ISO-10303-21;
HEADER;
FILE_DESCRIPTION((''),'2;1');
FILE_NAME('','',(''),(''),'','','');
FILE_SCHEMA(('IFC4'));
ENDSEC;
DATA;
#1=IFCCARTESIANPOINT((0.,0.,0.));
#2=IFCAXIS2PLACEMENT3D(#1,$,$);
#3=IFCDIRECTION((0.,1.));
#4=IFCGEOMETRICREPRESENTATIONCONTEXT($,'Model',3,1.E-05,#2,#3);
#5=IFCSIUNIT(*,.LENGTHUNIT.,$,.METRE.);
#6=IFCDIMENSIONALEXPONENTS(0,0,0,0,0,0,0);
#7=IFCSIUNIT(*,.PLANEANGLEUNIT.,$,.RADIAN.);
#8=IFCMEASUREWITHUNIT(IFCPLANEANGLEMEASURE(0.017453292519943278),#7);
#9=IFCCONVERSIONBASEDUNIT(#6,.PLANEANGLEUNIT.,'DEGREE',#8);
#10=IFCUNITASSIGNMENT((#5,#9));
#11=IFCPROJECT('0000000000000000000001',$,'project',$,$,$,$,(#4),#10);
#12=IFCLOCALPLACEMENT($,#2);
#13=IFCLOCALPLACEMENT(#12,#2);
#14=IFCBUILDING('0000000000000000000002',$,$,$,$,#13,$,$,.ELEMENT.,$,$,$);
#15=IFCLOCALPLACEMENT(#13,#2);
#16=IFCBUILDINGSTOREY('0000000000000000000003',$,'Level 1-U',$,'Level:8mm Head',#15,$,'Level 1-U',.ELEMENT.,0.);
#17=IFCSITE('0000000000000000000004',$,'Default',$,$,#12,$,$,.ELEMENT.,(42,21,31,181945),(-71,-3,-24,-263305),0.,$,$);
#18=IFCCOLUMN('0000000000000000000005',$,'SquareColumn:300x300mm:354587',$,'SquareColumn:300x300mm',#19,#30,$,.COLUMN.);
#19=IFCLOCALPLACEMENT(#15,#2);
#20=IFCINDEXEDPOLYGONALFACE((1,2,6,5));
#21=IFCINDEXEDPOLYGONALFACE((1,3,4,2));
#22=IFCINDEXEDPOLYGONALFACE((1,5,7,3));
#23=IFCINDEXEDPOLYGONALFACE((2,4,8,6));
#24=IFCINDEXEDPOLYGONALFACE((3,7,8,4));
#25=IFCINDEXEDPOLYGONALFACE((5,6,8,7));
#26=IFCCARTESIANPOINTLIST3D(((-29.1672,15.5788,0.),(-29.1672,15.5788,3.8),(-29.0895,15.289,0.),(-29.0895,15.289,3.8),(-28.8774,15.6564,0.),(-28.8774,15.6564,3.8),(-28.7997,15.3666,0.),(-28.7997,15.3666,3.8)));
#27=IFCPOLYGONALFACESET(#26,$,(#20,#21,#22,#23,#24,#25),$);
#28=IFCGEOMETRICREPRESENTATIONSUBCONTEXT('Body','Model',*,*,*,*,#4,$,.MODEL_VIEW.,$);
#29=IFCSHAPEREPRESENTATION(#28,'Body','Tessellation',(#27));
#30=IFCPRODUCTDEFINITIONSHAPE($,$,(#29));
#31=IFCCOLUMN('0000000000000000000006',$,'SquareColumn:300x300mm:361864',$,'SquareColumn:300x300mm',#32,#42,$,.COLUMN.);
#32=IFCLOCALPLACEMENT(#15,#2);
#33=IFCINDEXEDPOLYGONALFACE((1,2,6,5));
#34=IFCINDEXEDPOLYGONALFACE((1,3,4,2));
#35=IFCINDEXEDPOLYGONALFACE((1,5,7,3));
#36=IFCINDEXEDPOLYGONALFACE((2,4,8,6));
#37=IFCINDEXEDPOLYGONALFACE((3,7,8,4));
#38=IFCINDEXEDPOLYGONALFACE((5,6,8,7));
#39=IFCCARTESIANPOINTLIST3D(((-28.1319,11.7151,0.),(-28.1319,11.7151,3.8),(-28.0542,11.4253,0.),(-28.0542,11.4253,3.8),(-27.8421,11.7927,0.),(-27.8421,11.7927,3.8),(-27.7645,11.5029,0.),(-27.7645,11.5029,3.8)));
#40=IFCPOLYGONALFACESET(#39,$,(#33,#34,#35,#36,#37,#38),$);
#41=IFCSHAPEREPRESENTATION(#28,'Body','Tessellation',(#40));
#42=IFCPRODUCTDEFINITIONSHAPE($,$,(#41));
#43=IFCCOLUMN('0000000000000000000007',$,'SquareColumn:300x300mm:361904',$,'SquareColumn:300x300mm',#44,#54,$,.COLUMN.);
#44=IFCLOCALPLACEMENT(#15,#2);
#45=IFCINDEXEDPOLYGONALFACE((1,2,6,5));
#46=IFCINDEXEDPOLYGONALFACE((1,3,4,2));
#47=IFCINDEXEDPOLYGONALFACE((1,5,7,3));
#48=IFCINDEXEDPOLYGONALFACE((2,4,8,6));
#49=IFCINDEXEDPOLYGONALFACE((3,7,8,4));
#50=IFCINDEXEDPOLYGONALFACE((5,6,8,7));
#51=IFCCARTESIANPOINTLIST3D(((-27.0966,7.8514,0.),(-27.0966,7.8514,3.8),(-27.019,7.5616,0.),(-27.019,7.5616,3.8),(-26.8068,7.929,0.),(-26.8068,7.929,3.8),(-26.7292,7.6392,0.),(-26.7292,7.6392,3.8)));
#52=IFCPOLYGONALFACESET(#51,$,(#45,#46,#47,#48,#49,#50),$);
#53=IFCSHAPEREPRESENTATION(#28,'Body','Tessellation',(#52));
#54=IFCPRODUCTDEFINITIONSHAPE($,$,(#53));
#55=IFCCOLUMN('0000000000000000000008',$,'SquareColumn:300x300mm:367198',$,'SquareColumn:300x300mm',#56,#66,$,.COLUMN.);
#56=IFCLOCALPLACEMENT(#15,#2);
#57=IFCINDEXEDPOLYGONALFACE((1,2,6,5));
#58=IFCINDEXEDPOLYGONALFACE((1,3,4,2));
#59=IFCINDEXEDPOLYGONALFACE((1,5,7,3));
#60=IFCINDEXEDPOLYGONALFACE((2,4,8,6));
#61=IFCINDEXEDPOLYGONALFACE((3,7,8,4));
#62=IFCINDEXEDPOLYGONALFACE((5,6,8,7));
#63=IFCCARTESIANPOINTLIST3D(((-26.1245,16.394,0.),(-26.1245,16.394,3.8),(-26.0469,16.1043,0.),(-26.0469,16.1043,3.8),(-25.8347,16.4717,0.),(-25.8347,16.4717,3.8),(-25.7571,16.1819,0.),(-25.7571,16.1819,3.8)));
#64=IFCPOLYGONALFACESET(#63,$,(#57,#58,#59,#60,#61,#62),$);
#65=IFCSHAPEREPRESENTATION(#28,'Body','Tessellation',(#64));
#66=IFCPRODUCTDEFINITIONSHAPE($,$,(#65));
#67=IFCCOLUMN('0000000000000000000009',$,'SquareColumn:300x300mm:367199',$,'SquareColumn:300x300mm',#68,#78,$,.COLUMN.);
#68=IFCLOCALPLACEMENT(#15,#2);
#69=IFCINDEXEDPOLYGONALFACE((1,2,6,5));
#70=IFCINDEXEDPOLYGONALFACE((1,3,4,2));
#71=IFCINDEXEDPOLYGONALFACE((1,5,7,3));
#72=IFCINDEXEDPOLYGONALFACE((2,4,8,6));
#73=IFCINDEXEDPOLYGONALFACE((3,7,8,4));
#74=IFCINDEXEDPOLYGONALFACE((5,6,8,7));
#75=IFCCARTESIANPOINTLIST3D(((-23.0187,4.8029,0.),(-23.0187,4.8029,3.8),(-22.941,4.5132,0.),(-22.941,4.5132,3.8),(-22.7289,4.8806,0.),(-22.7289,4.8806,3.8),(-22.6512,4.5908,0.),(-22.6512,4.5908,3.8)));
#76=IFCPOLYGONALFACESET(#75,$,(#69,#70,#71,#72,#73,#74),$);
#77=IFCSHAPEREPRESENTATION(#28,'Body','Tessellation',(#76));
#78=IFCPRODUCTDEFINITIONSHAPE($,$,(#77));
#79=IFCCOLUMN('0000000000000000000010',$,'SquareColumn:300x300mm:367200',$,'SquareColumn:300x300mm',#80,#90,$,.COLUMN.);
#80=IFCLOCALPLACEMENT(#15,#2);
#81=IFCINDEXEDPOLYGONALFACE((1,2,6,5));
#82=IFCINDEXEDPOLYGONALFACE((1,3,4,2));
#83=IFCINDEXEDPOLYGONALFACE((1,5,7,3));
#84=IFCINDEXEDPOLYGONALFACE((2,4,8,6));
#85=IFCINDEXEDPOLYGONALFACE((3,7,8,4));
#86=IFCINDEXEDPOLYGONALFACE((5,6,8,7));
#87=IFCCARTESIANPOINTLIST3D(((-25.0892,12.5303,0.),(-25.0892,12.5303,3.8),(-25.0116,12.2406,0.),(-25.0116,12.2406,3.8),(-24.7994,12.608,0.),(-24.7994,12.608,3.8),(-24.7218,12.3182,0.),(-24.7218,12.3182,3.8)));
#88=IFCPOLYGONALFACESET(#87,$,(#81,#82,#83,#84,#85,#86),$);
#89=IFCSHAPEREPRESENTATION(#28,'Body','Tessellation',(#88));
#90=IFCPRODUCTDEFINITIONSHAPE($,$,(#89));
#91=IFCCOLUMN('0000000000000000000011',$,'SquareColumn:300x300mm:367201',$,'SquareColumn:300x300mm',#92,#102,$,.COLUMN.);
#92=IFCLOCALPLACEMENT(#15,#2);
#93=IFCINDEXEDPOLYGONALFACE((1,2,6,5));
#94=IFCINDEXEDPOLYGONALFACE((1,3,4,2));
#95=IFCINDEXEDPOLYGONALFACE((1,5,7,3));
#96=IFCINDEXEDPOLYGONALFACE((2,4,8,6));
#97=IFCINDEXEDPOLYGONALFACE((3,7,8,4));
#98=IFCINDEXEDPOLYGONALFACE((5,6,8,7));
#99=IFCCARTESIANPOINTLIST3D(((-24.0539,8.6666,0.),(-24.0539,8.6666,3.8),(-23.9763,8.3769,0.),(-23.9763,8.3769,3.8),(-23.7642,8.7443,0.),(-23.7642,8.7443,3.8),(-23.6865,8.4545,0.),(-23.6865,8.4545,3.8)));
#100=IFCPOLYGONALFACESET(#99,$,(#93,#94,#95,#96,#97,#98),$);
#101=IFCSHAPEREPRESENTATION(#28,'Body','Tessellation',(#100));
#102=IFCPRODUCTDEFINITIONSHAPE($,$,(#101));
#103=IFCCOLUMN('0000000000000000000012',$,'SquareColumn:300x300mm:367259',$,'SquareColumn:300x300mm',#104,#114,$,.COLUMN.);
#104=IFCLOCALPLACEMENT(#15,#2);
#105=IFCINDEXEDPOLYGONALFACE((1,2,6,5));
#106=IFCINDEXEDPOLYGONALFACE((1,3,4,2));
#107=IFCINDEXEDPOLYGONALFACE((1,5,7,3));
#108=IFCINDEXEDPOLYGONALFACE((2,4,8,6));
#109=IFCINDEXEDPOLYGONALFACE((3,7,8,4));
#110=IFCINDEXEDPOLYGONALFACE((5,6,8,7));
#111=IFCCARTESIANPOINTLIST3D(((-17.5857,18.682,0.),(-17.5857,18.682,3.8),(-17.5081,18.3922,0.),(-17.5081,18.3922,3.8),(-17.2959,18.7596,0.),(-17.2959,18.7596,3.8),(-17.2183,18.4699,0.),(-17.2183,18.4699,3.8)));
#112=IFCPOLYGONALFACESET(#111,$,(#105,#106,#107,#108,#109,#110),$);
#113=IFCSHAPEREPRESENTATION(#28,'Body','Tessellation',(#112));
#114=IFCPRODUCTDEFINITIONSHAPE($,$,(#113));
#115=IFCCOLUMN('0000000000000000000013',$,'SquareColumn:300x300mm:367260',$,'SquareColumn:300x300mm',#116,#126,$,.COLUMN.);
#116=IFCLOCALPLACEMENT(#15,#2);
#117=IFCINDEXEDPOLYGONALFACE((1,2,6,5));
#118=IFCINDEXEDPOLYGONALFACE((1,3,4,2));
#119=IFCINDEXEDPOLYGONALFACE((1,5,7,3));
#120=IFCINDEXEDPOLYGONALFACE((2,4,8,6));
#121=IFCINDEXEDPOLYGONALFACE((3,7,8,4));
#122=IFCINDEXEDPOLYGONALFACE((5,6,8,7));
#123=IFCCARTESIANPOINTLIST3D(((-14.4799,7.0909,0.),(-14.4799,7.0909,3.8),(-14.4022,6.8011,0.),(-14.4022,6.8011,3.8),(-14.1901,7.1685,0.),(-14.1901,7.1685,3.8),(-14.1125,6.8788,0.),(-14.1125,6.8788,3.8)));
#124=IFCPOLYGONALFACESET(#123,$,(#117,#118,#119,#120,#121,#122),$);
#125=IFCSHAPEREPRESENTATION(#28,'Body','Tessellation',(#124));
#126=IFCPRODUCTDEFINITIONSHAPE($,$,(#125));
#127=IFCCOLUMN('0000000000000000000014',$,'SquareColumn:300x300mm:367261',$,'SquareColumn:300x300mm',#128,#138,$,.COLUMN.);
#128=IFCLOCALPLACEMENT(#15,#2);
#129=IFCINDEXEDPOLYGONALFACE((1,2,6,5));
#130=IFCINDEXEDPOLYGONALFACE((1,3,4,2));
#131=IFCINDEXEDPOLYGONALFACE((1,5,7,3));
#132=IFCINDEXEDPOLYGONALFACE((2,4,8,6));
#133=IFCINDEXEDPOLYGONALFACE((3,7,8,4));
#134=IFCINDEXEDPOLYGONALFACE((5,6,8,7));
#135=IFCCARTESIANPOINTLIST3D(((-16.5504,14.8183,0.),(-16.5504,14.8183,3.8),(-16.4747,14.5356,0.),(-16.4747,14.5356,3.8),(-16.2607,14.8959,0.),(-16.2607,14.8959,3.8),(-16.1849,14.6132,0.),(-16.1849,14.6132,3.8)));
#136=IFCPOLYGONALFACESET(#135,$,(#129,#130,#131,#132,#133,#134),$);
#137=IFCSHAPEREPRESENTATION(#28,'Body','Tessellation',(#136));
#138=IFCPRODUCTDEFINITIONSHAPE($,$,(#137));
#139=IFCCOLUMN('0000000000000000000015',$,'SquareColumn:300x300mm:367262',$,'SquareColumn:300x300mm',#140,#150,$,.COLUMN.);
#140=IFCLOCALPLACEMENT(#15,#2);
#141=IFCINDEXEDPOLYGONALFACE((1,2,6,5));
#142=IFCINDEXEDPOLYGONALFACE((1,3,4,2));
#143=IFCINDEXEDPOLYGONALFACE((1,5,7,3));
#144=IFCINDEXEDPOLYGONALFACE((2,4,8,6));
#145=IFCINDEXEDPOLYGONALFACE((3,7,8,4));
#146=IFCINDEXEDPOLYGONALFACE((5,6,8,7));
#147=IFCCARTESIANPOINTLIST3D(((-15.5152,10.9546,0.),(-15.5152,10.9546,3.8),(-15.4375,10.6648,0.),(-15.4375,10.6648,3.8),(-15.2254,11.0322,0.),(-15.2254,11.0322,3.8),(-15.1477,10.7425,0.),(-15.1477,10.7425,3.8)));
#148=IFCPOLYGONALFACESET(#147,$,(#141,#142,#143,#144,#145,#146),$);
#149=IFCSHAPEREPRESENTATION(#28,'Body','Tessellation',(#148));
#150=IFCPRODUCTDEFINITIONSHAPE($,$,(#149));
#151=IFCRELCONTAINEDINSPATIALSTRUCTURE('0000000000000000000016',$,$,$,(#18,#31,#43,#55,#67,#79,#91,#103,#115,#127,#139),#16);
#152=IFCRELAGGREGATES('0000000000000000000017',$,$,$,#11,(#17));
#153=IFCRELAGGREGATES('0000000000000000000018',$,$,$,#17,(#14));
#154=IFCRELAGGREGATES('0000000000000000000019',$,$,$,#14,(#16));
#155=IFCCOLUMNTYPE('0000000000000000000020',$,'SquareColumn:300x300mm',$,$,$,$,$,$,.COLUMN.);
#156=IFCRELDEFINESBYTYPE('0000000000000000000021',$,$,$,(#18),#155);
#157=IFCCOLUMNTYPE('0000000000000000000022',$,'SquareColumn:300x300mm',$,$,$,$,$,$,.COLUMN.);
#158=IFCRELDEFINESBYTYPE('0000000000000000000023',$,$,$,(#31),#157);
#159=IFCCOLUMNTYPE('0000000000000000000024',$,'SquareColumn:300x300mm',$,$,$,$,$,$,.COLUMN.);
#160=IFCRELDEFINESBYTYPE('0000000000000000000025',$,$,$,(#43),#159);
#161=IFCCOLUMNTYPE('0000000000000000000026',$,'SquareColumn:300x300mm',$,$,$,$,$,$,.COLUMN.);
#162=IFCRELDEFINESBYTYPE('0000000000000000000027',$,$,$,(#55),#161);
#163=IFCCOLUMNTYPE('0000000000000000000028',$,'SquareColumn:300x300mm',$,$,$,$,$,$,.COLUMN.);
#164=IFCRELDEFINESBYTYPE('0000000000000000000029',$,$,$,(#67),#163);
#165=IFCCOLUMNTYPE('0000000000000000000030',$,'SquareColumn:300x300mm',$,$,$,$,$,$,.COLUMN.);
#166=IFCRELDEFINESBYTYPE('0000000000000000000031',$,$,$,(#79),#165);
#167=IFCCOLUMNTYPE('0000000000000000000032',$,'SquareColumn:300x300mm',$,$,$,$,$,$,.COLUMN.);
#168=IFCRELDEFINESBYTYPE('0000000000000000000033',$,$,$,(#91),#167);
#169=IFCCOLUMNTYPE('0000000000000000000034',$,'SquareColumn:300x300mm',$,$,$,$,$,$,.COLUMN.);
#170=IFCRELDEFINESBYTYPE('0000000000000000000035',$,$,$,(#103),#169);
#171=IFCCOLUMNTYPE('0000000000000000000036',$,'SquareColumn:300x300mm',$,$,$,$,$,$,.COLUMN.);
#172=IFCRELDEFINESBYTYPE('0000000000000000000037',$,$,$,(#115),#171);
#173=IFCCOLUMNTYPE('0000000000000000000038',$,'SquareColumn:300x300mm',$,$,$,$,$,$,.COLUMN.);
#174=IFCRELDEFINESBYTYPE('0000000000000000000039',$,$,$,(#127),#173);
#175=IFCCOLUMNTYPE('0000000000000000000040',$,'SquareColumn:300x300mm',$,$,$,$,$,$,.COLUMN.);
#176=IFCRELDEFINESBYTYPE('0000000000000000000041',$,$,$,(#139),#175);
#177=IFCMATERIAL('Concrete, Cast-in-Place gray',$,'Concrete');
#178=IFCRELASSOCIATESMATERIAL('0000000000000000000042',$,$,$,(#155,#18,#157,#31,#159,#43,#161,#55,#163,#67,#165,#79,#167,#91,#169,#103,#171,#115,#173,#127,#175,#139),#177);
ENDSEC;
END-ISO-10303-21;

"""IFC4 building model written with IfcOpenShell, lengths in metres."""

from ifc_helpers import new_model, entity, si_unit, converted_unit, direction, frame, origin, place, context, subcontext, project, spatial, indexed_curve, outline, extrude, source, transform, mapped, material, type_object, type_shapes, element, save


model = new_model("IFC4")

# Units and contexts
model_context = context("Model", 3, precision=1e-05, world=origin(), true_north=direction((0.0, 1.0)))
body_context = subcontext(model_context, "Body", "Model", "MODEL_VIEW")
ifc_project = project(units=[si_unit("LENGTHUNIT", "METRE"), converted_unit("PLANEANGLEUNIT", "DEGREE", entity("IfcPlaneAngleMeasure", 0.017453292519943278), si_unit("PLANEANGLEUNIT", "RADIAN"), dimensions=[0, 0, 0, 0, 0, 0, 0])], contexts=[model_context])

# Site, building, storey
site_placement = place(None, origin())
site = spatial("IfcSite", under=ifc_project, at=site_placement, Name="Default", CompositionType="ELEMENT", RefLatitude=(42, 21, 31, 181945), RefLongitude=(-71, -3, -24, -263305), RefElevation=0.0)
building_placement = place(site_placement, origin())
building = spatial("IfcBuilding", under=site, at=building_placement, CompositionType="ELEMENT")
storey_placement = place(building_placement, origin())
storey = spatial("IfcBuildingStorey", under=building, at=storey_placement, Name="Level 1-U", ObjectType="Level:8mm Head", LongName="Level 1-U", CompositionType="ELEMENT", Elevation=0.0)

# Columns
ifc_material_1 = material(Name="Concrete, Cast-in-Place gray", Category="Concrete")
column_type_1 = type_object("IfcColumnType", Name="SquareColumn:300x300mm", PredefinedType="COLUMN", material=ifc_material_1)
shared_shape_1 = source(origin(), body_context, "Body", "SweptSolid", [
    extrude(outline(indexed_curve([(-0.15, -0.15), (0.15, -0.15), (0.15, 0.15), (-0.15, 0.15), (-0.15, -0.15)], self_intersect=False)), frame((-28.9835, 15.4727, 0.0), z_axis=(0.0, 0.0, 1.0), x_axis=(-0.258819, 0.965926, 0.0)), (0.0, 0.0, 1.0), 3.8),
])
type_shapes(column_type_1, [shared_shape_1])
column_1_placement = place(storey_placement, origin())
element("IfcColumn", 1, at=column_1_placement, inside=storey, type_object=column_type_1, material=ifc_material_1, Name="SquareColumn:300x300mm:354587", ObjectType="SquareColumn:300x300mm", PredefinedType="COLUMN", context=body_context, shape_type="MappedRepresentation", body=[
    mapped(shared_shape_1, transform((0.0, 0.0, 0.0), scale=1.0)),
])
column_type_2 = type_object("IfcColumnType", Name="SquareColumn:300x300mm", PredefinedType="COLUMN", material=ifc_material_1)
shared_shape_2 = source(origin(), body_context, "Body", "SweptSolid", [
    extrude(outline(indexed_curve([(-0.15, -0.15), (0.15, -0.15), (0.15, 0.15), (-0.15, 0.15), (-0.15, -0.15)], self_intersect=False)), frame((-27.9482, 11.609, 0.0), z_axis=(0.0, 0.0, 1.0), x_axis=(-0.258819, 0.965926, 0.0)), (0.0, 0.0, 1.0), 3.8),
])
type_shapes(column_type_2, [shared_shape_2])
column_2_placement = place(storey_placement, origin())
element("IfcColumn", 2, at=column_2_placement, inside=storey, type_object=column_type_2, material=ifc_material_1, Name="SquareColumn:300x300mm:361864", ObjectType="SquareColumn:300x300mm", PredefinedType="COLUMN", context=body_context, shape_type="MappedRepresentation", body=[
    mapped(shared_shape_2, transform((0.0, 0.0, 0.0), scale=1.0)),
])
column_type_3 = type_object("IfcColumnType", Name="SquareColumn:300x300mm", PredefinedType="COLUMN", material=ifc_material_1)
shared_shape_3 = source(origin(), body_context, "Body", "SweptSolid", [
    extrude(outline(indexed_curve([(-0.15, -0.15), (0.15, -0.15), (0.15, 0.15), (-0.15, 0.15), (-0.15, -0.15)], self_intersect=False)), frame((-26.9129, 7.7453, 0.0), z_axis=(0.0, 0.0, 1.0), x_axis=(-0.258819, 0.965926, 0.0)), (0.0, 0.0, 1.0), 3.8),
])
type_shapes(column_type_3, [shared_shape_3])
column_3_placement = place(storey_placement, origin())
element("IfcColumn", 3, at=column_3_placement, inside=storey, type_object=column_type_3, material=ifc_material_1, Name="SquareColumn:300x300mm:361904", ObjectType="SquareColumn:300x300mm", PredefinedType="COLUMN", context=body_context, shape_type="MappedRepresentation", body=[
    mapped(shared_shape_3, transform((0.0, 0.0, 0.0), scale=1.0)),
])
column_type_4 = type_object("IfcColumnType", Name="SquareColumn:300x300mm", PredefinedType="COLUMN", material=ifc_material_1)
shared_shape_4 = source(origin(), body_context, "Body", "SweptSolid", [
    extrude(outline(indexed_curve([(-0.15, -0.15), (0.15, -0.15), (0.15, 0.15), (-0.15, 0.15), (-0.15, -0.15)], self_intersect=False)), frame((-25.9408, 16.288, 0.0), z_axis=(0.0, 0.0, 1.0), x_axis=(-0.258819, 0.965926, 0.0)), (0.0, 0.0, 1.0), 3.8),
])
type_shapes(column_type_4, [shared_shape_4])
column_4_placement = place(storey_placement, origin())
element("IfcColumn", 4, at=column_4_placement, inside=storey, type_object=column_type_4, material=ifc_material_1, Name="SquareColumn:300x300mm:367198", ObjectType="SquareColumn:300x300mm", PredefinedType="COLUMN", context=body_context, shape_type="MappedRepresentation", body=[
    mapped(shared_shape_4, transform((0.0, 0.0, 0.0), scale=1.0)),
])
column_type_5 = type_object("IfcColumnType", Name="SquareColumn:300x300mm", PredefinedType="COLUMN", material=ifc_material_1)
shared_shape_5 = source(origin(), body_context, "Body", "SweptSolid", [
    extrude(outline(indexed_curve([(-0.15, -0.15), (0.15, -0.15), (0.15, 0.15), (-0.15, 0.15), (-0.15, -0.15)], self_intersect=False)), frame((-22.835, 4.6969, 0.0), z_axis=(0.0, 0.0, 1.0), x_axis=(-0.258819, 0.965926, 0.0)), (0.0, 0.0, 1.0), 3.8),
])
type_shapes(column_type_5, [shared_shape_5])
column_5_placement = place(storey_placement, origin())
element("IfcColumn", 5, at=column_5_placement, inside=storey, type_object=column_type_5, material=ifc_material_1, Name="SquareColumn:300x300mm:367199", ObjectType="SquareColumn:300x300mm", PredefinedType="COLUMN", context=body_context, shape_type="MappedRepresentation", body=[
    mapped(shared_shape_5, transform((0.0, 0.0, 0.0), scale=1.0)),
])
column_type_6 = type_object("IfcColumnType", Name="SquareColumn:300x300mm", PredefinedType="COLUMN", material=ifc_material_1)
shared_shape_6 = source(origin(), body_context, "Body", "SweptSolid", [
    extrude(outline(indexed_curve([(-0.15, -0.15), (0.15, -0.15), (0.15, 0.15), (-0.15, 0.15), (-0.15, -0.15)], self_intersect=False)), frame((-24.9055, 12.4243, 0.0), z_axis=(0.0, 0.0, 1.0), x_axis=(-0.258819, 0.965926, 0.0)), (0.0, 0.0, 1.0), 3.8),
])
type_shapes(column_type_6, [shared_shape_6])
column_6_placement = place(storey_placement, origin())
element("IfcColumn", 6, at=column_6_placement, inside=storey, type_object=column_type_6, material=ifc_material_1, Name="SquareColumn:300x300mm:367200", ObjectType="SquareColumn:300x300mm", PredefinedType="COLUMN", context=body_context, shape_type="MappedRepresentation", body=[
    mapped(shared_shape_6, transform((0.0, 0.0, 0.0), scale=1.0)),
])
column_type_7 = type_object("IfcColumnType", Name="SquareColumn:300x300mm", PredefinedType="COLUMN", material=ifc_material_1)
shared_shape_7 = source(origin(), body_context, "Body", "SweptSolid", [
    extrude(outline(indexed_curve([(-0.15, -0.15), (0.15, -0.15), (0.15, 0.15), (-0.15, 0.15), (-0.15, -0.15)], self_intersect=False)), frame((-23.8702, 8.5606, 0.0), z_axis=(0.0, 0.0, 1.0), x_axis=(-0.258819, 0.965926, 0.0)), (0.0, 0.0, 1.0), 3.8),
])
type_shapes(column_type_7, [shared_shape_7])
column_7_placement = place(storey_placement, origin())
element("IfcColumn", 7, at=column_7_placement, inside=storey, type_object=column_type_7, material=ifc_material_1, Name="SquareColumn:300x300mm:367201", ObjectType="SquareColumn:300x300mm", PredefinedType="COLUMN", context=body_context, shape_type="MappedRepresentation", body=[
    mapped(shared_shape_7, transform((0.0, 0.0, 0.0), scale=1.0)),
])
column_type_8 = type_object("IfcColumnType", Name="SquareColumn:300x300mm", PredefinedType="COLUMN", material=ifc_material_1)
shared_shape_8 = source(origin(), body_context, "Body", "SweptSolid", [
    extrude(outline(indexed_curve([(-0.15, -0.15), (0.15, -0.15), (0.15, 0.15), (-0.15, 0.15), (-0.15, -0.15)], self_intersect=False)), frame((-17.402, 18.5759, 0.0), z_axis=(0.0, 0.0, 1.0), x_axis=(-0.258819, 0.965926, 0.0)), (0.0, 0.0, 1.0), 3.8),
])
type_shapes(column_type_8, [shared_shape_8])
column_8_placement = place(storey_placement, origin())
element("IfcColumn", 8, at=column_8_placement, inside=storey, type_object=column_type_8, material=ifc_material_1, Name="SquareColumn:300x300mm:367259", ObjectType="SquareColumn:300x300mm", PredefinedType="COLUMN", context=body_context, shape_type="MappedRepresentation", body=[
    mapped(shared_shape_8, transform((0.0, 0.0, 0.0), scale=1.0)),
])
column_type_9 = type_object("IfcColumnType", Name="SquareColumn:300x300mm", PredefinedType="COLUMN", material=ifc_material_1)
shared_shape_9 = source(origin(), body_context, "Body", "SweptSolid", [
    extrude(outline(indexed_curve([(-0.15, -0.15), (0.15, -0.15), (0.15, 0.15), (-0.15, 0.15), (-0.15, -0.15)], self_intersect=False)), frame((-14.2962, 6.9848, 0.0), z_axis=(0.0, 0.0, 1.0), x_axis=(-0.258819, 0.965926, 0.0)), (0.0, 0.0, 1.0), 3.8),
])
type_shapes(column_type_9, [shared_shape_9])
column_9_placement = place(storey_placement, origin())
element("IfcColumn", 9, at=column_9_placement, inside=storey, type_object=column_type_9, material=ifc_material_1, Name="SquareColumn:300x300mm:367260", ObjectType="SquareColumn:300x300mm", PredefinedType="COLUMN", context=body_context, shape_type="MappedRepresentation", body=[
    mapped(shared_shape_9, transform((0.0, 0.0, 0.0), scale=1.0)),
])
column_type_10 = type_object("IfcColumnType", Name="SquareColumn:300x300mm", PredefinedType="COLUMN", material=ifc_material_1)
shared_shape_10 = source(origin(), body_context, "Body", "SweptSolid", [
    extrude(outline(indexed_curve([(-0.1464, -0.15), (0.1464, -0.15), (0.1464, 0.15), (-0.1464, 0.15), (-0.1464, -0.15)], self_intersect=False)), frame((-16.3677, 14.7157, 0.0), z_axis=(0.0, 0.0, 1.0), x_axis=(-0.258819, 0.965926, 0.0)), (0.0, 0.0, 1.0), 3.8),
])
type_shapes(column_type_10, [shared_shape_10])
column_10_placement = place(storey_placement, origin())
element("IfcColumn", 10, at=column_10_placement, inside=storey, type_object=column_type_10, material=ifc_material_1, Name="SquareColumn:300x300mm:367261", ObjectType="SquareColumn:300x300mm", PredefinedType="COLUMN", context=body_context, shape_type="MappedRepresentation", body=[
    mapped(shared_shape_10, transform((0.0, 0.0, 0.0), scale=1.0)),
])
column_type_11 = type_object("IfcColumnType", Name="SquareColumn:300x300mm", PredefinedType="COLUMN", material=ifc_material_1)
shared_shape_11 = source(origin(), body_context, "Body", "SweptSolid", [
    extrude(outline(indexed_curve([(-0.15, -0.15), (0.15, -0.15), (0.15, 0.15), (-0.15, 0.15), (-0.15, -0.15)], self_intersect=False)), frame((-15.3314, 10.8485, 0.0), z_axis=(0.0, 0.0, 1.0), x_axis=(-0.258819, 0.965926, 0.0)), (0.0, 0.0, 1.0), 3.8),
])
type_shapes(column_type_11, [shared_shape_11])
column_11_placement = place(storey_placement, origin())
element("IfcColumn", 11, at=column_11_placement, inside=storey, type_object=column_type_11, material=ifc_material_1, Name="SquareColumn:300x300mm:367262", ObjectType="SquareColumn:300x300mm", PredefinedType="COLUMN", context=body_context, shape_type="MappedRepresentation", body=[
    mapped(shared_shape_11, transform((0.0, 0.0, 0.0), scale=1.0)),
])

save(model, "model.ifc")
